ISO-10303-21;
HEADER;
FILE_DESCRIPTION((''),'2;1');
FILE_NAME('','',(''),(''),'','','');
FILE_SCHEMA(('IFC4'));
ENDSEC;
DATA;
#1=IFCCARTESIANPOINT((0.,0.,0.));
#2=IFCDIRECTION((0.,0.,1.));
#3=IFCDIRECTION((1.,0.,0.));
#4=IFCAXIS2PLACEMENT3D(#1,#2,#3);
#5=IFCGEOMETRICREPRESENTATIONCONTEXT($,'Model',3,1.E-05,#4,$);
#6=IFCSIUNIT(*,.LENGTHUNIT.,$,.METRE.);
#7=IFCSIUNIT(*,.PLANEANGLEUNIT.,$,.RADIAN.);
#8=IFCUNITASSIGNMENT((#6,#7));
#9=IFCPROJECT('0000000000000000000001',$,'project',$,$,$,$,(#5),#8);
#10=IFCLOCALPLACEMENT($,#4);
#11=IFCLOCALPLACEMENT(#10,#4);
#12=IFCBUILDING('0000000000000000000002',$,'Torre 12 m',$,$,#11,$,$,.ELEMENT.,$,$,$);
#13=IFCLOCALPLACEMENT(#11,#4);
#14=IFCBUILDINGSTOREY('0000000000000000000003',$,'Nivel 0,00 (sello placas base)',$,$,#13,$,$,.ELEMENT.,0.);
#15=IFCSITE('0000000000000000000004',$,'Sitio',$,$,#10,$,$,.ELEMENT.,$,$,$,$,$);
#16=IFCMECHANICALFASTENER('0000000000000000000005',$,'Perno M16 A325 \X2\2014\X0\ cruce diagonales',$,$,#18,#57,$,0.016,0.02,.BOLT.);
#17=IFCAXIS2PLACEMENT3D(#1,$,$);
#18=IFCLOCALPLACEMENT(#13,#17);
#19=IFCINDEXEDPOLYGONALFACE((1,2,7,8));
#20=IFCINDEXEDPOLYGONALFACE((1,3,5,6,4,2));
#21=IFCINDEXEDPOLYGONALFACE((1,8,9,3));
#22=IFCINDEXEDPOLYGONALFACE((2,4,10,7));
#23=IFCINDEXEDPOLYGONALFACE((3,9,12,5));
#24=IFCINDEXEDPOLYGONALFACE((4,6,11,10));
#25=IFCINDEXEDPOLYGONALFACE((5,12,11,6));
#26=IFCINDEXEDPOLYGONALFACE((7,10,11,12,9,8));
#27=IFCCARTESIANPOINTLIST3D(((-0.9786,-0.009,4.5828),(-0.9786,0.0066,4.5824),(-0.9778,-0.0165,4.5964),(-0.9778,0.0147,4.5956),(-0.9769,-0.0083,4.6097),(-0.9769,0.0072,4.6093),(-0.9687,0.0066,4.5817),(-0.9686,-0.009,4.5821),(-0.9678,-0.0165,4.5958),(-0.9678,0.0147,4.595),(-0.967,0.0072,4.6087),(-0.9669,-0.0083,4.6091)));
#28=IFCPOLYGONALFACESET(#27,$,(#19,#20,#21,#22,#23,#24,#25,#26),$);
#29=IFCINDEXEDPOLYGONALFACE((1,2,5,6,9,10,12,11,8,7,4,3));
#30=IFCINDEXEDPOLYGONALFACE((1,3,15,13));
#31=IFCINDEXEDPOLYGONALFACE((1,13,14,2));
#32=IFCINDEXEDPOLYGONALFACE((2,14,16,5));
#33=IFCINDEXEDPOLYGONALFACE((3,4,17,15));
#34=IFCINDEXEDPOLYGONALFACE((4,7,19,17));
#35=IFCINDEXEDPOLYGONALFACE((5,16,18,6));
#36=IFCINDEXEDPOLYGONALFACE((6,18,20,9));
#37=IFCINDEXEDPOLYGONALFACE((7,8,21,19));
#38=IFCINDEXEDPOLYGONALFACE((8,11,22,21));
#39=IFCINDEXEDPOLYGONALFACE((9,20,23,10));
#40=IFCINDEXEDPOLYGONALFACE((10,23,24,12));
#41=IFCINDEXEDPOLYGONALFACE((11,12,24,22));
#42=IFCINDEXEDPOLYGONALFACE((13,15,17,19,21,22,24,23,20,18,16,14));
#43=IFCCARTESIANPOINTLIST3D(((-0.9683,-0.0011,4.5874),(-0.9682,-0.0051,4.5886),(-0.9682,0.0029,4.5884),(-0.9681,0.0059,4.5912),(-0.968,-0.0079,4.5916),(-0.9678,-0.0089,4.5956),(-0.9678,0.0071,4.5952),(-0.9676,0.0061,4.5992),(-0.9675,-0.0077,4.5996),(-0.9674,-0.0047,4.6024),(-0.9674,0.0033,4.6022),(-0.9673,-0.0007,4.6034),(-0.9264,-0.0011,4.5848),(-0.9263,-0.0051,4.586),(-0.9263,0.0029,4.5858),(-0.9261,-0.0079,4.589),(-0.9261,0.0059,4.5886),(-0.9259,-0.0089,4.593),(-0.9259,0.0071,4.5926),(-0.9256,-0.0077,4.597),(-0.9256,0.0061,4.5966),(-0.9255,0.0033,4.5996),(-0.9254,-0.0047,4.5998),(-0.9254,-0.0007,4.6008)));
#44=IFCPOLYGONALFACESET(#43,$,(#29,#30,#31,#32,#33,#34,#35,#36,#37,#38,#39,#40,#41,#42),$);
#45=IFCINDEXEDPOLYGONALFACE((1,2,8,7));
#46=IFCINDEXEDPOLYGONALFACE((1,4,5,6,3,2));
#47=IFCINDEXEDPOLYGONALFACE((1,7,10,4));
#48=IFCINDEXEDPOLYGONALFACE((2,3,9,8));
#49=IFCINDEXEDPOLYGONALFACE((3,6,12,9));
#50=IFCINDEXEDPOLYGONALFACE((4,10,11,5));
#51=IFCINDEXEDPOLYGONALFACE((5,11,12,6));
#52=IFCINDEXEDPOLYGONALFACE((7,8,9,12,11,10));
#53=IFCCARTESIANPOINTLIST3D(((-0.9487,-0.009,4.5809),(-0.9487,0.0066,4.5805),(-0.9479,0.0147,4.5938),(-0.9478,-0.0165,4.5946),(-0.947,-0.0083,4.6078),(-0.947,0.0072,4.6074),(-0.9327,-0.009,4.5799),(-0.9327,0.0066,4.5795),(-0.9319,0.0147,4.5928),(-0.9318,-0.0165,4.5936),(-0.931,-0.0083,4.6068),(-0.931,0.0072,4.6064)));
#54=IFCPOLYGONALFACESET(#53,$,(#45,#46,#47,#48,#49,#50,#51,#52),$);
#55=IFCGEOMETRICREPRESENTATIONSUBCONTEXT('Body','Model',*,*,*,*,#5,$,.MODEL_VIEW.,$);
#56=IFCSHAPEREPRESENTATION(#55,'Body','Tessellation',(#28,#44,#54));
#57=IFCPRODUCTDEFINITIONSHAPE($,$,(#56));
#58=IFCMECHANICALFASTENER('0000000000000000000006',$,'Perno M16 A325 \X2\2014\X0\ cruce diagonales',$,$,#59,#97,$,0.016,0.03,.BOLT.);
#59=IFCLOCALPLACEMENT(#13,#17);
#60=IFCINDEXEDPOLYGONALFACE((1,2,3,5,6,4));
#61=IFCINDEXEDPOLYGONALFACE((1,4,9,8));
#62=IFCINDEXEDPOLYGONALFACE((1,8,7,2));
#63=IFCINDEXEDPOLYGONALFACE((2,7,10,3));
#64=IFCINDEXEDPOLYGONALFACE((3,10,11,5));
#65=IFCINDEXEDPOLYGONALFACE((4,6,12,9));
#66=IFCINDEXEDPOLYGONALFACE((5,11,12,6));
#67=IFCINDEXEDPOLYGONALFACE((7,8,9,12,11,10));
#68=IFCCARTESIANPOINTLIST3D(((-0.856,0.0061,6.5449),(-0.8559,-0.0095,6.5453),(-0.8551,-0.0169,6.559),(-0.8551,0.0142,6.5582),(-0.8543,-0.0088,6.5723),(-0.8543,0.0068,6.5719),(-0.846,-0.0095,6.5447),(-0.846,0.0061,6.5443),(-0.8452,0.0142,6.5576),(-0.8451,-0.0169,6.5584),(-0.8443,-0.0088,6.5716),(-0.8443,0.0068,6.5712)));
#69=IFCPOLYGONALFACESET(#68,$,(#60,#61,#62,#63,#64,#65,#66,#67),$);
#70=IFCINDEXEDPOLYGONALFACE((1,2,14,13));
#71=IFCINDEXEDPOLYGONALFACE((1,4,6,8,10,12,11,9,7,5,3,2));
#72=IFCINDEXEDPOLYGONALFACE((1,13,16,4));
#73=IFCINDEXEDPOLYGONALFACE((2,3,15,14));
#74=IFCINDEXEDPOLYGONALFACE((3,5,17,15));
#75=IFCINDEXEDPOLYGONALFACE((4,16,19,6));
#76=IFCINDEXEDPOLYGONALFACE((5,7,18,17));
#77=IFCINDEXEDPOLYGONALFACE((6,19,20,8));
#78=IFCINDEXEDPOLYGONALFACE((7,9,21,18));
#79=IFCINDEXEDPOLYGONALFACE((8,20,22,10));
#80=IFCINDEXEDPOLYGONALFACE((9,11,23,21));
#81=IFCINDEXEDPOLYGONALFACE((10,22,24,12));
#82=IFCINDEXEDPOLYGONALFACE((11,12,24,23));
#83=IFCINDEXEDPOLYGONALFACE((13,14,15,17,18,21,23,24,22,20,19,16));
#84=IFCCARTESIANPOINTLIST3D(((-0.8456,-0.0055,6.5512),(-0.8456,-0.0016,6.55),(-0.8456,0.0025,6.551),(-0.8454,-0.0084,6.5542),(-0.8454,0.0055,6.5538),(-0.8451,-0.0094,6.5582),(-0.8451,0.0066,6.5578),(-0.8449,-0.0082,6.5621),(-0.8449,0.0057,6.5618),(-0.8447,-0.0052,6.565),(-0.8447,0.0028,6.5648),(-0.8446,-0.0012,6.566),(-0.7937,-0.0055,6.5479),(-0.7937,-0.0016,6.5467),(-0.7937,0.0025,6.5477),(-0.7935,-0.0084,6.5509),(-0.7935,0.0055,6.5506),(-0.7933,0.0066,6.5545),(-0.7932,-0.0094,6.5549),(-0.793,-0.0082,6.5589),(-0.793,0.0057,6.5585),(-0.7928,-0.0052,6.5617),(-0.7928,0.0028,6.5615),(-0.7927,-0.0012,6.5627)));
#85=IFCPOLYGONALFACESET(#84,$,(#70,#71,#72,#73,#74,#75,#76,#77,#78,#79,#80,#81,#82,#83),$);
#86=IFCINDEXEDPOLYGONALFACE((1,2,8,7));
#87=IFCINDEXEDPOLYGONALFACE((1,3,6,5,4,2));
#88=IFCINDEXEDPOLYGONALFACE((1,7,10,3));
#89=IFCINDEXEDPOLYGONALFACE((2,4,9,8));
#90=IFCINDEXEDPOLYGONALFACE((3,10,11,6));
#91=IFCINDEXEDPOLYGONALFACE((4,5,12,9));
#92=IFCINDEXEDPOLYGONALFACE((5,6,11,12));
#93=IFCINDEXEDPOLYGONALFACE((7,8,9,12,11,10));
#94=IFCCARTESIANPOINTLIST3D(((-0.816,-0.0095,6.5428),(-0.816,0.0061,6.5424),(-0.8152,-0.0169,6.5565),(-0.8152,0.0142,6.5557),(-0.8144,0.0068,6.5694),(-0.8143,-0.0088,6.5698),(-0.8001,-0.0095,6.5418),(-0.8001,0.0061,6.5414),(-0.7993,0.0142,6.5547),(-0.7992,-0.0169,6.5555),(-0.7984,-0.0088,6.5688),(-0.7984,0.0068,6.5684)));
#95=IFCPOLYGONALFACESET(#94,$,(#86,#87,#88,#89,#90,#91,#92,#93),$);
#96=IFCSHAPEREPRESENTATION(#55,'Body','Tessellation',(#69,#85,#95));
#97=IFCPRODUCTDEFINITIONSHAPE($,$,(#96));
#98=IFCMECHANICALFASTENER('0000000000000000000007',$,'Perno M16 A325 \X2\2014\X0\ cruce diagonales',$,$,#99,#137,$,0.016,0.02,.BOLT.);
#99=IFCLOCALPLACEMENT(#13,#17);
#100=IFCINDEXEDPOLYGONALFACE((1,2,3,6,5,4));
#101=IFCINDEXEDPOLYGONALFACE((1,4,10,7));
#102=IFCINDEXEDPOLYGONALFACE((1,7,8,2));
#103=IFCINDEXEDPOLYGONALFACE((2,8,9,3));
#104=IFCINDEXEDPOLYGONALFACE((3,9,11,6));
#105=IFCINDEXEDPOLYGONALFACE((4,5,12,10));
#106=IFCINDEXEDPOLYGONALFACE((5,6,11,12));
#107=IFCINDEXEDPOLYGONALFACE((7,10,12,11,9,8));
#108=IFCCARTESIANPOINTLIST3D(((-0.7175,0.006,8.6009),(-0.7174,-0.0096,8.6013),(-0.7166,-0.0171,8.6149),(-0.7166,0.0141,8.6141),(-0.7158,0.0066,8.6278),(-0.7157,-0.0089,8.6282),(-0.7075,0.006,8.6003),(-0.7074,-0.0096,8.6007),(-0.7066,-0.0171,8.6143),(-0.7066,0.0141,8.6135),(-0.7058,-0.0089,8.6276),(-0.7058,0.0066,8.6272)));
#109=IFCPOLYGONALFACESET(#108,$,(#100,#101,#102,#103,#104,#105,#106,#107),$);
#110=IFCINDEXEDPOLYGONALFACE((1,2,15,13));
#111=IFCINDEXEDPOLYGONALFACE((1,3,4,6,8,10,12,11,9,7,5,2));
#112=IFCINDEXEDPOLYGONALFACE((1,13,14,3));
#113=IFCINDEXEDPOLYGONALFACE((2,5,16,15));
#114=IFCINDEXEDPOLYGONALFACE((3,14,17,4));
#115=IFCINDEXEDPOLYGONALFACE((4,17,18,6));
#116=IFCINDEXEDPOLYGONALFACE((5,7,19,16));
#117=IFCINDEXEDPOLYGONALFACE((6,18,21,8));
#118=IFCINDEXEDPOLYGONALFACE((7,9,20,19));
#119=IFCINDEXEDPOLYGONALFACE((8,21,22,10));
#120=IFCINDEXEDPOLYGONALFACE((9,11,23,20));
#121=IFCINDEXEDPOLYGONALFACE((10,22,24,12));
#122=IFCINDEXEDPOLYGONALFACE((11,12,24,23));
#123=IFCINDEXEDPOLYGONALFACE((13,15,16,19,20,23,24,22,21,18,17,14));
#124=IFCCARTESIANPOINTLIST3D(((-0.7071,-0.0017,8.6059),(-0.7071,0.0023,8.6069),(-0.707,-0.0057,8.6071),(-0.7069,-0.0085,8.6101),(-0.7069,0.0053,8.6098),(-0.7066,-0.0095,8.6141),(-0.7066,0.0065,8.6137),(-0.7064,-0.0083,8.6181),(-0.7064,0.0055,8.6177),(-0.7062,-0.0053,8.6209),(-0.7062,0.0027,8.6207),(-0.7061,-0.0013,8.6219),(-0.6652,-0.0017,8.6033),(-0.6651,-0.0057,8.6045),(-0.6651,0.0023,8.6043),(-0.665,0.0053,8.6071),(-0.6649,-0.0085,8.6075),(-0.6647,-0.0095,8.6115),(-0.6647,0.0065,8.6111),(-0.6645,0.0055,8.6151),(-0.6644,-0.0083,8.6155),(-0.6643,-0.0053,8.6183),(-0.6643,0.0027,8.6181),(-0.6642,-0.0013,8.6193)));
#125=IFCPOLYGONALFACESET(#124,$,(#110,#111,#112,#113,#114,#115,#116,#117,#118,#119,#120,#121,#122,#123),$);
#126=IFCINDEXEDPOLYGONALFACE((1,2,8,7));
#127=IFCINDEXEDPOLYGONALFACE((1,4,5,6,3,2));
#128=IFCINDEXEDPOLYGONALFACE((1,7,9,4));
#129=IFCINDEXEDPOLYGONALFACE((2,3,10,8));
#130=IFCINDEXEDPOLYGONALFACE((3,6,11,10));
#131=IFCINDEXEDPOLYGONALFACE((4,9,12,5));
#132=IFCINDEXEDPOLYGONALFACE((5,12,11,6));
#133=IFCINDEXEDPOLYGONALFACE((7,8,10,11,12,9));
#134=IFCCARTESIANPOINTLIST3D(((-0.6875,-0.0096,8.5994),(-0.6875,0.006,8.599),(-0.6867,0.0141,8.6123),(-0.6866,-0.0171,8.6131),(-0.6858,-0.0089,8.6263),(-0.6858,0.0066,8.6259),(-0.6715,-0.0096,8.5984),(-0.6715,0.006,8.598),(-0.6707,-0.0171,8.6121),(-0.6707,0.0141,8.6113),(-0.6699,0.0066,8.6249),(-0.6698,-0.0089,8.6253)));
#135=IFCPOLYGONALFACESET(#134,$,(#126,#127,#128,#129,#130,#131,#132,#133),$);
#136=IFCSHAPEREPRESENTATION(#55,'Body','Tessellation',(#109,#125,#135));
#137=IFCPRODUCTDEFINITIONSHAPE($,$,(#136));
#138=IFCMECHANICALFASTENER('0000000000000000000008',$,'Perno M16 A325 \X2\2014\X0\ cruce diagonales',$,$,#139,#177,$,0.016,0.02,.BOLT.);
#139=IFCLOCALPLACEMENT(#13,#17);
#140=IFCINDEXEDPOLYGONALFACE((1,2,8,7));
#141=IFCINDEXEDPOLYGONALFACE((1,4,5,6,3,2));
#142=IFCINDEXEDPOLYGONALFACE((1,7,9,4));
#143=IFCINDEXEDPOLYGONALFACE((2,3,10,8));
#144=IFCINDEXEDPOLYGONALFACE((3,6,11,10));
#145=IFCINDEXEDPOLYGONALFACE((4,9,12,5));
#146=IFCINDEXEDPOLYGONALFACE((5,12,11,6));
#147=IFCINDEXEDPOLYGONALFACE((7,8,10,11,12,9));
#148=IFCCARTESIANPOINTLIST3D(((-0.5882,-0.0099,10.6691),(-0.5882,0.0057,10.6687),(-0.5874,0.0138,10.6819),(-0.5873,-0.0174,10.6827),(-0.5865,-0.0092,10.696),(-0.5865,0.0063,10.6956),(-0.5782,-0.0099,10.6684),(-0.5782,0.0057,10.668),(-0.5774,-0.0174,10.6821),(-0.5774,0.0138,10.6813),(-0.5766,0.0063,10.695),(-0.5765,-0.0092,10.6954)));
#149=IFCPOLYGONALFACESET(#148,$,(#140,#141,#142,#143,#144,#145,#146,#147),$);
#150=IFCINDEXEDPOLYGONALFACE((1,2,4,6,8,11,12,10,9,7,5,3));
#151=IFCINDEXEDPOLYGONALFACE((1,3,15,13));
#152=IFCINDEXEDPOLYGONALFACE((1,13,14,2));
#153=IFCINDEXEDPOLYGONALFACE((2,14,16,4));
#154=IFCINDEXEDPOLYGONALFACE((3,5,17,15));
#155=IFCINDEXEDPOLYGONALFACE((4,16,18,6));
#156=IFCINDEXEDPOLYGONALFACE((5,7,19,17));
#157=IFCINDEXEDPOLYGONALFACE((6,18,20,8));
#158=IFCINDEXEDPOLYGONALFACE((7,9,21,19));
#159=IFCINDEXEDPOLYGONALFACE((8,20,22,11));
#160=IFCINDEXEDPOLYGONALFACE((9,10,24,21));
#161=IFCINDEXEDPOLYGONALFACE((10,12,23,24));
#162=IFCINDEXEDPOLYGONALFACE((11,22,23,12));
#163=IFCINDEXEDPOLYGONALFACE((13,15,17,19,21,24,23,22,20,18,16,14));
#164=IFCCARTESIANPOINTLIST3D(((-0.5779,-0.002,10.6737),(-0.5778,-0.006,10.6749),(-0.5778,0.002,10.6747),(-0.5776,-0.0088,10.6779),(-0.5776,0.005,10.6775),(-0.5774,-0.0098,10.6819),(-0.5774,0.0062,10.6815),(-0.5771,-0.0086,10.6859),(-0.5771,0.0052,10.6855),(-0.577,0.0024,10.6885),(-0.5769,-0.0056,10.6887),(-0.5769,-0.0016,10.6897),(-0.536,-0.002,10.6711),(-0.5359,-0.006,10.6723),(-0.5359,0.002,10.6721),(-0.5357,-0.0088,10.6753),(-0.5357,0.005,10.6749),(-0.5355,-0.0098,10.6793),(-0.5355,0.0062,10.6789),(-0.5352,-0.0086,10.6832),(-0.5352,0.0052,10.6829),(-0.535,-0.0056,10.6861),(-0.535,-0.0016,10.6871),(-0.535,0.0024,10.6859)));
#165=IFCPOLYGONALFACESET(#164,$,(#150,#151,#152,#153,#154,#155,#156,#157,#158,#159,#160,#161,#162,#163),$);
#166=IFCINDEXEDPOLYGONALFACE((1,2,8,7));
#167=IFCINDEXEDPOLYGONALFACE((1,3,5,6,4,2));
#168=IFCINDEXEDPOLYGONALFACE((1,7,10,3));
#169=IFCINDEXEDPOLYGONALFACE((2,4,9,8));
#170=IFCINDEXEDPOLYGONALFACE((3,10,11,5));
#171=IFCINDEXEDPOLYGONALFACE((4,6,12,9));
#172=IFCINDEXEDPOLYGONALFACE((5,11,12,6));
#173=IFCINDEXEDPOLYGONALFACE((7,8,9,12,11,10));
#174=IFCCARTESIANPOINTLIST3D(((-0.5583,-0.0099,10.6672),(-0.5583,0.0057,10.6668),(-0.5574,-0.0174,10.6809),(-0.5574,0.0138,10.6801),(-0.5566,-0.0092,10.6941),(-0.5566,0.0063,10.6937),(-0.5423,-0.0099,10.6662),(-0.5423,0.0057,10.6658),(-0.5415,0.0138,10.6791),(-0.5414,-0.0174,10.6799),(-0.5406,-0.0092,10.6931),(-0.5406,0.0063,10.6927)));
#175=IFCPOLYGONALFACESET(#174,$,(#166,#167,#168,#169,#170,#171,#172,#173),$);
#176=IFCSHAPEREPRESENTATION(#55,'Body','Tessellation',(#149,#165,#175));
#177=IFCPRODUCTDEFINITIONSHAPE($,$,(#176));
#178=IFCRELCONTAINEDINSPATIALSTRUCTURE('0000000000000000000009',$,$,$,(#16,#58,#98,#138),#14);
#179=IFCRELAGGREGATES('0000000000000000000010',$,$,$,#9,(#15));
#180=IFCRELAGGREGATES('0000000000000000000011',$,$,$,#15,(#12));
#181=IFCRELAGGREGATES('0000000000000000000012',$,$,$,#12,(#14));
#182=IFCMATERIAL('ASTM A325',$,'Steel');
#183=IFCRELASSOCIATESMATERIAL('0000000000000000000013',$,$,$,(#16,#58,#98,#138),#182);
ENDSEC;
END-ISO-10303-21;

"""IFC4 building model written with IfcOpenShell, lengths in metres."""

from ifc_helpers import new_model, si_unit, frame, origin_with_axes, place, context, subcontext, project, spatial, polyline, outline, extrude, material, element, save


model = new_model("IFC4")

# Units and contexts
model_context = context("Model", 3, precision=1e-05, world=origin_with_axes())
body_context = subcontext(model_context, "Body", "Model", "MODEL_VIEW")
ifc_project = project(units=[si_unit("LENGTHUNIT", "METRE"), si_unit("PLANEANGLEUNIT", "RADIAN")], contexts=[model_context])

# Site, building, storey
site_placement = place(None, origin_with_axes())
site = spatial("IfcSite", under=ifc_project, at=site_placement, Name="Sitio", CompositionType="ELEMENT")
building_placement = place(site_placement, origin_with_axes())
building = spatial("IfcBuilding", under=site, at=building_placement, Name="Torre 12 m", CompositionType="ELEMENT")
storey_placement = place(building_placement, origin_with_axes())
storey = spatial("IfcBuildingStorey", under=building, at=storey_placement, Name="Nivel 0,00 (sello placas base)", CompositionType="ELEMENT", Elevation=0.0)

# Shared definitions
placement = place(storey_placement, origin_with_axes())

# Mechanical fasteners
ifc_material_1 = material(Name="ASTM A325", Category="Steel")
element("IfcMechanicalFastener", 1, at=placement, inside=storey, material=ifc_material_1, Name="Perno M16 A325 — cruce diagonales", NominalDiameter=0.016, NominalLength=0.02, PredefinedType="BOLT", context=body_context, shape_type="SweptSolid", body=[
    extrude(outline(polyline([(0.0135, 0.0078), (0.0, 0.0156), (-0.0135, 0.0078), (-0.0135, -0.0078), (0.0, -0.0156), (0.0135, -0.0078), (0.0135, 0.0078)])), frame((-0.9778, -0.0009, 4.596), z_axis=(0.998053, 0.0, -0.062378), x_axis=(0.032557, -0.85299, 0.52091)), (0.0, 0.0, 1.0), 0.01),
    extrude(outline(polyline([(0.008, 0.0), (0.0069, 0.004), (0.004, 0.0069), (0.0, 0.008), (-0.004, 0.0069), (-0.0069, 0.004), (-0.008, 0.0), (-0.0069, -0.004), (-0.004, -0.0069), (0.0, -0.008), (0.004, -0.0069), (0.0069, -0.004), (0.008, 0.0)])), frame((-0.9678, -0.0009, 4.5954), z_axis=(0.998053, 0.0, -0.062378), x_axis=(0.032557, -0.85299, 0.52091)), (0.0, 0.0, 1.0), 0.042),
    extrude(outline(polyline([(0.0135, 0.0078), (0.0, 0.0156), (-0.0135, 0.0078), (-0.0135, -0.0078), (0.0, -0.0156), (0.0135, -0.0078), (0.0135, 0.0078)])), frame((-0.9478, -0.0009, 4.5942), z_axis=(0.998053, 0.0, -0.062378), x_axis=(0.032557, -0.85299, 0.52091)), (0.0, 0.0, 1.0), 0.016),
])
element("IfcMechanicalFastener", 2, at=placement, inside=storey, material=ifc_material_1, Name="Perno M16 A325 — cruce diagonales", NominalDiameter=0.016, NominalLength=0.03, PredefinedType="BOLT", context=body_context, shape_type="SweptSolid", body=[
    extrude(outline(polyline([(0.0135, 0.0078), (0.0, 0.0156), (-0.0135, 0.0078), (-0.0135, -0.0078), (0.0, -0.0156), (0.0135, -0.0078), (0.0135, 0.0078)])), frame((-0.8551, -0.0014, 6.5586), z_axis=(0.998053, 0.0, -0.062378), x_axis=(0.032557, -0.85299, 0.52091)), (0.0, 0.0, 1.0), 0.01),
    extrude(outline(polyline([(0.008, 0.0), (0.0069, 0.004), (0.004, 0.0069), (0.0, 0.008), (-0.004, 0.0069), (-0.0069, 0.004), (-0.008, 0.0), (-0.0069, -0.004), (-0.004, -0.0069), (0.0, -0.008), (0.004, -0.0069), (0.0069, -0.004), (0.008, 0.0)])), frame((-0.8451, -0.0014, 6.558), z_axis=(0.998053, 0.0, -0.062378), x_axis=(0.032557, -0.85299, 0.52091)), (0.0, 0.0, 1.0), 0.052),
    extrude(outline(polyline([(0.0135, 0.0078), (0.0, 0.0156), (-0.0135, 0.0078), (-0.0135, -0.0078), (0.0, -0.0156), (0.0135, -0.0078), (0.0135, 0.0078)])), frame((-0.8152, -0.0014, 6.5561), z_axis=(0.998053, 0.0, -0.062378), x_axis=(0.032557, -0.85299, 0.52091)), (0.0, 0.0, 1.0), 0.016),
])
element("IfcMechanicalFastener", 3, at=placement, inside=storey, material=ifc_material_1, Name="Perno M16 A325 — cruce diagonales", NominalDiameter=0.016, NominalLength=0.02, PredefinedType="BOLT", context=body_context, shape_type="SweptSolid", body=[
    extrude(outline(polyline([(0.0135, 0.0078), (0.0, 0.0156), (-0.0135, 0.0078), (-0.0135, -0.0078), (0.0, -0.0156), (0.0135, -0.0078), (0.0135, 0.0078)])), frame((-0.7166, -0.0015, 8.6145), z_axis=(0.998053, 0.0, -0.062378), x_axis=(0.032557, -0.85299, 0.52091)), (0.0, 0.0, 1.0), 0.01),
    extrude(outline(polyline([(0.008, 0.0), (0.0069, 0.004), (0.004, 0.0069), (0.0, 0.008), (-0.004, 0.0069), (-0.0069, 0.004), (-0.008, 0.0), (-0.0069, -0.004), (-0.004, -0.0069), (0.0, -0.008), (0.004, -0.0069), (0.0069, -0.004), (0.008, 0.0)])), frame((-0.7066, -0.0015, 8.6139), z_axis=(0.998053, 0.0, -0.062378), x_axis=(0.032557, -0.85299, 0.52091)), (0.0, 0.0, 1.0), 0.042),
    extrude(outline(polyline([(0.0135, 0.0078), (0.0, 0.0156), (-0.0135, 0.0078), (-0.0135, -0.0078), (0.0, -0.0156), (0.0135, -0.0078), (0.0135, 0.0078)])), frame((-0.6867, -0.0015, 8.6127), z_axis=(0.998053, 0.0, -0.062378), x_axis=(0.032557, -0.85299, 0.52091)), (0.0, 0.0, 1.0), 0.016),
])
element("IfcMechanicalFastener", 4, at=placement, inside=storey, material=ifc_material_1, Name="Perno M16 A325 — cruce diagonales", NominalDiameter=0.016, NominalLength=0.02, PredefinedType="BOLT", context=body_context, shape_type="SweptSolid", body=[
    extrude(outline(polyline([(0.0135, 0.0078), (0.0, 0.0156), (-0.0135, 0.0078), (-0.0135, -0.0078), (0.0, -0.0156), (0.0135, -0.0078), (0.0135, 0.0078)])), frame((-0.5874, -0.0018, 10.6823), z_axis=(0.998053, 0.0, -0.062378), x_axis=(0.032557, -0.85299, 0.52091)), (0.0, 0.0, 1.0), 0.01),
    extrude(outline(polyline([(0.008, 0.0), (0.0069, 0.004), (0.004, 0.0069), (0.0, 0.008), (-0.004, 0.0069), (-0.0069, 0.004), (-0.008, 0.0), (-0.0069, -0.004), (-0.004, -0.0069), (0.0, -0.008), (0.004, -0.0069), (0.0069, -0.004), (0.008, 0.0)])), frame((-0.5774, -0.0018, 10.6817), z_axis=(0.998053, 0.0, -0.062378), x_axis=(0.032557, -0.85299, 0.52091)), (0.0, 0.0, 1.0), 0.042),
    extrude(outline(polyline([(0.0135, 0.0078), (0.0, 0.0156), (-0.0135, 0.0078), (-0.0135, -0.0078), (0.0, -0.0156), (0.0135, -0.0078), (0.0135, 0.0078)])), frame((-0.5574, -0.0018, 10.6805), z_axis=(0.998053, 0.0, -0.062378), x_axis=(0.032557, -0.85299, 0.52091)), (0.0, 0.0, 1.0), 0.016),
])

save(model, "model.ifc")
